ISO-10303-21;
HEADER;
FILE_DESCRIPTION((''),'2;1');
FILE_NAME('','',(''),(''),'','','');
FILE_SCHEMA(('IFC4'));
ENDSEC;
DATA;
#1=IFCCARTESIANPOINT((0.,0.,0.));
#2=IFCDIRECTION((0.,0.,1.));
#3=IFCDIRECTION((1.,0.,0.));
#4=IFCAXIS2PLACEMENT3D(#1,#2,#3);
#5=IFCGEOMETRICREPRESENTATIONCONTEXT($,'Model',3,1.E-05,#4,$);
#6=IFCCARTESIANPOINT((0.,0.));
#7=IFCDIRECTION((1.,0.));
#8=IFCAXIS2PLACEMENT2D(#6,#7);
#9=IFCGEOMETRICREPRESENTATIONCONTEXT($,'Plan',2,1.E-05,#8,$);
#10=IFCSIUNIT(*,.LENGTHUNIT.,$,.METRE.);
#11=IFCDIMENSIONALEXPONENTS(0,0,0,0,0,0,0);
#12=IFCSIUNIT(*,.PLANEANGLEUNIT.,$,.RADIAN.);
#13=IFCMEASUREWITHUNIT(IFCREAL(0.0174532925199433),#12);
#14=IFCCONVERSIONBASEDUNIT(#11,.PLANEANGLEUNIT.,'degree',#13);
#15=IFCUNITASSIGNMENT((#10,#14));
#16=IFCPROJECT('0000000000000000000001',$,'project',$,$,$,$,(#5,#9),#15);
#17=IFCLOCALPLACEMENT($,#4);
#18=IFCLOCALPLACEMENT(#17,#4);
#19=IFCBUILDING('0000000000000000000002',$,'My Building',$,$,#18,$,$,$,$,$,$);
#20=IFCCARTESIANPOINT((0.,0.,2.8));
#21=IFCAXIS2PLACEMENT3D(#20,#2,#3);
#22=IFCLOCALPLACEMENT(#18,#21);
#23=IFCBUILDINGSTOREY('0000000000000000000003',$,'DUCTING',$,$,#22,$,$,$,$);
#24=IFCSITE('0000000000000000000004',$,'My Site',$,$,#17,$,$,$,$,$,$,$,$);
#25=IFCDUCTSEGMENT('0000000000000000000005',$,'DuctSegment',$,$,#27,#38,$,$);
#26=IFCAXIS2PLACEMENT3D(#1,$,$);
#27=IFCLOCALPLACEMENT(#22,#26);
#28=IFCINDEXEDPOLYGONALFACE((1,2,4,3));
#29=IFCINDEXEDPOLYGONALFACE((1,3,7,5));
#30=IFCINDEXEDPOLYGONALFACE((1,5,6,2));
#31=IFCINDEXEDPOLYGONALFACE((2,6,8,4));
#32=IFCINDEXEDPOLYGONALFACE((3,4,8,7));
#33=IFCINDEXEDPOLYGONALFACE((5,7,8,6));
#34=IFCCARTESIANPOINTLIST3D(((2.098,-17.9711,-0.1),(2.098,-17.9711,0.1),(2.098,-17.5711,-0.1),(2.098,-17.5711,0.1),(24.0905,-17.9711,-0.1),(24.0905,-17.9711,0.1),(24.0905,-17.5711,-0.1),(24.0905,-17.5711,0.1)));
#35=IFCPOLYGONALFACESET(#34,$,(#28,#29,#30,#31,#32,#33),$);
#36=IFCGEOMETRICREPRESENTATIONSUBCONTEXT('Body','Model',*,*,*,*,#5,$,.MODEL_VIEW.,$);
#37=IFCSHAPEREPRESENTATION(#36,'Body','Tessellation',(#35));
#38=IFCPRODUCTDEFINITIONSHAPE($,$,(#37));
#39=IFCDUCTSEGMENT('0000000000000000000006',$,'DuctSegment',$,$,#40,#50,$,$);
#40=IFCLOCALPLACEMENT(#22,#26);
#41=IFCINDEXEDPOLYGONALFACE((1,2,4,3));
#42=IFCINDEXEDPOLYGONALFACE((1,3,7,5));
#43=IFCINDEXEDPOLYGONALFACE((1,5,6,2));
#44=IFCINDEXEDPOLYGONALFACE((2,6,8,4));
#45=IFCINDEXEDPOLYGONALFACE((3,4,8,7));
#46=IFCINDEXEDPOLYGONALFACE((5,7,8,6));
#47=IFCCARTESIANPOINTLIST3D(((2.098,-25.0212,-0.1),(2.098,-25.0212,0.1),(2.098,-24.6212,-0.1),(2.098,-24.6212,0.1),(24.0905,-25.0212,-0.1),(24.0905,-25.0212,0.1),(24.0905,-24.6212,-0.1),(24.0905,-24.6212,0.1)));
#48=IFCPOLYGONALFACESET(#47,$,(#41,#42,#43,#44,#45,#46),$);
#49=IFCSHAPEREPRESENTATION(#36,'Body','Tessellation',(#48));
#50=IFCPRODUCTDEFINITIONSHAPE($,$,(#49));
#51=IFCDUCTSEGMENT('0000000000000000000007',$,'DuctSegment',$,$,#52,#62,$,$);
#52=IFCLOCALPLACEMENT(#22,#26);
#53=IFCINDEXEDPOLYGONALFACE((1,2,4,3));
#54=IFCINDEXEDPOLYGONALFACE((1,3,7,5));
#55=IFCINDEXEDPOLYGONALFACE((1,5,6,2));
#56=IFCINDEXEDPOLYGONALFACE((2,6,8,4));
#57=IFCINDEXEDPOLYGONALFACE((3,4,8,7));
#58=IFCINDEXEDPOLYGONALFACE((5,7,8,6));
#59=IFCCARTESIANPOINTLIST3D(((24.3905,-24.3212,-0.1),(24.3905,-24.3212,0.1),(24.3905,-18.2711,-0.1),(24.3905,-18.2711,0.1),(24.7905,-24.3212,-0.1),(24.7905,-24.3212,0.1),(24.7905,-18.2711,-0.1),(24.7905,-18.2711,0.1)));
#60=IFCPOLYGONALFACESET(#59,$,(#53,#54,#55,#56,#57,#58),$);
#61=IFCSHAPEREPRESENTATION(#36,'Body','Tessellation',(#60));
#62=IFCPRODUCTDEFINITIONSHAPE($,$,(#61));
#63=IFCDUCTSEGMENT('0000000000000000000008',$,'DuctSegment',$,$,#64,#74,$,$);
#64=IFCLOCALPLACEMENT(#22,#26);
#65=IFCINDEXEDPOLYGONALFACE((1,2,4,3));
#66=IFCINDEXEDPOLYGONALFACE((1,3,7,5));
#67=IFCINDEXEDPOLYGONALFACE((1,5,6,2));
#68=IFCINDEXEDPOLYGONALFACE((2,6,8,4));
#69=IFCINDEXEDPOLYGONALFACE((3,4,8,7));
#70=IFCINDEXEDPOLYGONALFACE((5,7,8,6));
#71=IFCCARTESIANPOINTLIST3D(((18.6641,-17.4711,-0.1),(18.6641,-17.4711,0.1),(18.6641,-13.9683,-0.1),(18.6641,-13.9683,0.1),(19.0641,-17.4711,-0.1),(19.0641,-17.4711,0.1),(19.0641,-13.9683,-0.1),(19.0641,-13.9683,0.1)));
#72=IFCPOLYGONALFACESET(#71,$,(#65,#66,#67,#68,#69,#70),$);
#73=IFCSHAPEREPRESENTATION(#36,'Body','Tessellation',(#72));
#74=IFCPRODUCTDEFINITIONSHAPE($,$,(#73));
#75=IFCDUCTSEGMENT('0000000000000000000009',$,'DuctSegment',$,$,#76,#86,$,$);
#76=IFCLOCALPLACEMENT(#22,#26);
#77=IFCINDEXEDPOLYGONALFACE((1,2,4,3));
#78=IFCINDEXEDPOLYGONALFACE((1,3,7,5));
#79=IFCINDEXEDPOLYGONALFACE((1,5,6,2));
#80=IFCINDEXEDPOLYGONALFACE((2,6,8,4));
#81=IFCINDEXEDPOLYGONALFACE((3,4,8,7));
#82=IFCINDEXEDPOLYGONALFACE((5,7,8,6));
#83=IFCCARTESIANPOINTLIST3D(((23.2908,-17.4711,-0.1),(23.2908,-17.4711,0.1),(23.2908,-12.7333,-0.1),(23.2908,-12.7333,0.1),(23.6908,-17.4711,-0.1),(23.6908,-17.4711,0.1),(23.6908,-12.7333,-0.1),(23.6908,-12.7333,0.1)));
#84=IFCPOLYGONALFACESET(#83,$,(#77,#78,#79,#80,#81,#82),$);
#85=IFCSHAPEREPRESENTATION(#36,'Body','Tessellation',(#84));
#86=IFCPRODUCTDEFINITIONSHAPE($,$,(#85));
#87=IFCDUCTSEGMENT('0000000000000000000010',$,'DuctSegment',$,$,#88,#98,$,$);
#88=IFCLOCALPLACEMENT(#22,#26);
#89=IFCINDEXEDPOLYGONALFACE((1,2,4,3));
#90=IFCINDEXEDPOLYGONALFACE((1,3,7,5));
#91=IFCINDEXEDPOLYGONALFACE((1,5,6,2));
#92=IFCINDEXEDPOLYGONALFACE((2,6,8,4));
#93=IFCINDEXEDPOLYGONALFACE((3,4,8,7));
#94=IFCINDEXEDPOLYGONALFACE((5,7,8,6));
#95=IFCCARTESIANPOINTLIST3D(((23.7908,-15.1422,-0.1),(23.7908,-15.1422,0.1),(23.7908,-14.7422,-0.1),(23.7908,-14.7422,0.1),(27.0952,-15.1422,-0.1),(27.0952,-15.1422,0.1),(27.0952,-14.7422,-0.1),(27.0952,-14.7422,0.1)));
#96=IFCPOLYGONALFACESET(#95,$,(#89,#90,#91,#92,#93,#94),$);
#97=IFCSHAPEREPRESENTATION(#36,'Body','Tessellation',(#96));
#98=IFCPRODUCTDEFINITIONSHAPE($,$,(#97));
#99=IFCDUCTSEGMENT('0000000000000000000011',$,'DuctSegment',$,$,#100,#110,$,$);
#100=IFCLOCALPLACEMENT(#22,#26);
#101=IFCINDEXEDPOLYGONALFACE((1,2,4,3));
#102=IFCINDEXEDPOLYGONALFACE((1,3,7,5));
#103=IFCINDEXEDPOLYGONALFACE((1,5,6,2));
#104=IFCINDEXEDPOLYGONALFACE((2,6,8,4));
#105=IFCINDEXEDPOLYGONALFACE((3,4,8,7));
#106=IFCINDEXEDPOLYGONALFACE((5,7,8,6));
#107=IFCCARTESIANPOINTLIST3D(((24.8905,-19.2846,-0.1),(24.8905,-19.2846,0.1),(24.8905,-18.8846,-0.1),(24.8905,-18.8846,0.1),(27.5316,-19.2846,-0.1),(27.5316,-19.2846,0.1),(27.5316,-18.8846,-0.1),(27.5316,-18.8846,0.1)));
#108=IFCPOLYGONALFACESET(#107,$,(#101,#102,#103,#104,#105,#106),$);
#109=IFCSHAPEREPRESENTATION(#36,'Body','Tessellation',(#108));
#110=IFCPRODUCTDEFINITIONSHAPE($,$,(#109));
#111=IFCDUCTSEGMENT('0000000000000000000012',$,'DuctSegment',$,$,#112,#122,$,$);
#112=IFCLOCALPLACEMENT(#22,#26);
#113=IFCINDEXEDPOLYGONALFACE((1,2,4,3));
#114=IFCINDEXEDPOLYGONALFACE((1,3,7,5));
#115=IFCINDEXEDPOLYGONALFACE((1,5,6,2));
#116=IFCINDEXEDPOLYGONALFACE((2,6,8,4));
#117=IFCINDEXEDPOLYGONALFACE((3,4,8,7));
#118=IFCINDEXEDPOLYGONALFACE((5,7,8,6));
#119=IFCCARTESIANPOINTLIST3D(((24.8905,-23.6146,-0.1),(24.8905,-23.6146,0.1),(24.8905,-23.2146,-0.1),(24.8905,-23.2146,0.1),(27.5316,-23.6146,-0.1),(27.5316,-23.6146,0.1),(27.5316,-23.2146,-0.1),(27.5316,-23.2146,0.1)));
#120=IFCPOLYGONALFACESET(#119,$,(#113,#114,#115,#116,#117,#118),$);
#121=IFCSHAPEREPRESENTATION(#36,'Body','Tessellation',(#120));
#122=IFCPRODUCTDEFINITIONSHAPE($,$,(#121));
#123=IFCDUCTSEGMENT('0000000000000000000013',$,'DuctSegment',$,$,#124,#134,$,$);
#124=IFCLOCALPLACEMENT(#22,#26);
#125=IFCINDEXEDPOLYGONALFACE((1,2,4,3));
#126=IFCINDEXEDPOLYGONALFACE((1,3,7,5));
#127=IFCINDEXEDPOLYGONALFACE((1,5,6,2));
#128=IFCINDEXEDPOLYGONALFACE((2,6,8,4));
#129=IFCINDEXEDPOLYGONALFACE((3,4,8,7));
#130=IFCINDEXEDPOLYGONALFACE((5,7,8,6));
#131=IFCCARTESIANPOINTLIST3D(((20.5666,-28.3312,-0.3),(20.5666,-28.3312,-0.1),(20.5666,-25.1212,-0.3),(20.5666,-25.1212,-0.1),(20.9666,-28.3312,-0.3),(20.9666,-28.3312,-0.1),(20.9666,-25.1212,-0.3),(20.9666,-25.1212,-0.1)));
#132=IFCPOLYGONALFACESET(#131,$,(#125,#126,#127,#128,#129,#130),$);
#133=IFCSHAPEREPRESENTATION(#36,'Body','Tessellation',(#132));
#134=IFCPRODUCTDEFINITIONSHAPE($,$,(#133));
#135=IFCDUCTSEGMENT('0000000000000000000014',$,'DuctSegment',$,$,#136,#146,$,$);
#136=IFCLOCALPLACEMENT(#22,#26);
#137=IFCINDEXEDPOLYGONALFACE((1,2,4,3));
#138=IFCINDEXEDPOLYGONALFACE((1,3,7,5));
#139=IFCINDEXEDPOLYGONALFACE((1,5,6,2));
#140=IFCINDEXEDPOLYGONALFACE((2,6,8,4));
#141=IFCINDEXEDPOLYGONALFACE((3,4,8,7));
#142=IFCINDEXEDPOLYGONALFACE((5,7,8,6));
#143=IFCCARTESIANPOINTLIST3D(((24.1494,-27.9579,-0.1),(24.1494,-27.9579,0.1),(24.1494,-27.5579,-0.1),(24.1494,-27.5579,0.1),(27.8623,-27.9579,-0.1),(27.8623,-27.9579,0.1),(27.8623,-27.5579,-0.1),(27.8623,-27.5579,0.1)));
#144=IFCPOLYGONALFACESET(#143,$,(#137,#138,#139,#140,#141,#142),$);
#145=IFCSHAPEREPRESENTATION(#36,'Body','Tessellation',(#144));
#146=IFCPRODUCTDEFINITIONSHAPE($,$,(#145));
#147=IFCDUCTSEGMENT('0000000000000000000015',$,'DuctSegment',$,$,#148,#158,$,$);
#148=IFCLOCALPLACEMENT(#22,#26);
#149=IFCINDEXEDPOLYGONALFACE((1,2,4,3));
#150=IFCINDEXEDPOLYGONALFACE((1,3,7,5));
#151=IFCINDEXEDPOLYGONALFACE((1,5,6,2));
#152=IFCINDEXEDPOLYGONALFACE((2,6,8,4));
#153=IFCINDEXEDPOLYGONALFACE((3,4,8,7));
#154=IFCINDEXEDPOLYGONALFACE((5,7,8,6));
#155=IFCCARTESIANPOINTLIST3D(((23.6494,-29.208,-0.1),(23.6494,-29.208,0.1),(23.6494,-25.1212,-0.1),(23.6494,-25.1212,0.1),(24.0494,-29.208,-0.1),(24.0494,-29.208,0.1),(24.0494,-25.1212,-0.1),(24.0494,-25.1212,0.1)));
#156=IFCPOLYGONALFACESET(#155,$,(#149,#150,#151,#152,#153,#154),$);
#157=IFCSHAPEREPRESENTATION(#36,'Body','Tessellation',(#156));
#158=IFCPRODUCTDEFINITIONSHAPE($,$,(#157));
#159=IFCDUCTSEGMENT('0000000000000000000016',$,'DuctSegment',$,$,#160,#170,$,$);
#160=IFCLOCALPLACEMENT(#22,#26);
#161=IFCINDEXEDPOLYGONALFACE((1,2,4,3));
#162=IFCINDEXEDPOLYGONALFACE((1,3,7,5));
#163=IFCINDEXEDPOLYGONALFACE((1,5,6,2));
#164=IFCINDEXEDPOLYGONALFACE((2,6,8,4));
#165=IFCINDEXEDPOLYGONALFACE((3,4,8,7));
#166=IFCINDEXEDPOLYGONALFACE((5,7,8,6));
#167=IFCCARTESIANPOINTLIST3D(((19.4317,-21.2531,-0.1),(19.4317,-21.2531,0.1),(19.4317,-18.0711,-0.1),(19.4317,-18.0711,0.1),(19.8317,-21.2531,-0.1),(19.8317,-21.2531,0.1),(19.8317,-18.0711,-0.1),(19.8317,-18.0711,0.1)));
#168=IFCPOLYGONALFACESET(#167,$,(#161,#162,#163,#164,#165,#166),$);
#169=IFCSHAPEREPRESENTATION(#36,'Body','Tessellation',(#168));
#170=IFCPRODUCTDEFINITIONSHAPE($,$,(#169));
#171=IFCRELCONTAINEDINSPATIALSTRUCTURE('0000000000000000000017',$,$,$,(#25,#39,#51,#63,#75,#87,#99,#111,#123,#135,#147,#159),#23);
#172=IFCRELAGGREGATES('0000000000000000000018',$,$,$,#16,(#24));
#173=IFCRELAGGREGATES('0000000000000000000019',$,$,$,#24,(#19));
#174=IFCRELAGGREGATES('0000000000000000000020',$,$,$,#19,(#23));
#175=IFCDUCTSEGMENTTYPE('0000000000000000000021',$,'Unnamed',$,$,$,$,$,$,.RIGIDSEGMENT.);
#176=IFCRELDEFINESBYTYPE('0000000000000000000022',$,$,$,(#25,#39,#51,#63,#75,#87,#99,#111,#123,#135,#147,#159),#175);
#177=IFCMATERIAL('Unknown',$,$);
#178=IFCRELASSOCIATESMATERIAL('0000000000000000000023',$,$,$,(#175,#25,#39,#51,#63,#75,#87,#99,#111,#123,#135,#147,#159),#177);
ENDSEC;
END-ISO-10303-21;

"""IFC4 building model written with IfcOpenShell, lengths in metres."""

from ifc_helpers import new_model, entity, si_unit, converted_unit, frame, origin_with_axes, origin_2d_with_axis, place, context, subcontext, project, spatial, rectangle, extrude, material, material_profile, profile_set, profile_usage, type_object, element, save


model = new_model("IFC4")

# Units and contexts
model_context = context("Model", 3, precision=1e-05, world=origin_with_axes())
plan_context = context("Plan", 2, precision=1e-05, world=origin_2d_with_axis())
body_context = subcontext(model_context, "Body", "Model", "MODEL_VIEW")
ifc_project = project(units=[si_unit("LENGTHUNIT", "METRE"), converted_unit("PLANEANGLEUNIT", "degree", entity("IfcReal", 0.0174532925199433), si_unit("PLANEANGLEUNIT", "RADIAN"), dimensions=[0, 0, 0, 0, 0, 0, 0])], contexts=[model_context, plan_context])

# Site, building, storey
site_placement = place(None, origin_with_axes())
site = spatial("IfcSite", under=ifc_project, at=site_placement, Name="My Site")
building_placement = place(site_placement, origin_with_axes())
building = spatial("IfcBuilding", under=site, at=building_placement, Name="My Building")
storey_placement = place(building_placement, frame((0.0, 0.0, 2.8), z_axis=(0.0, 0.0, 1.0), x_axis=(1.0, 0.0, 0.0)))
storey = spatial("IfcBuildingStorey", under=building, at=storey_placement, Name="DUCTING")

# Duct segments
ifc_material = material(Name="Unknown")
ifc_material_profile_1 = material_profile(ifc_material, rectangle(XDim=0.4, YDim=0.2))
ifc_profile_set_1 = profile_set([ifc_material_profile_1])
ifc_profile_usage_1 = profile_usage(ifc_profile_set_1, cardinal=5)
duct_segment_type = type_object("IfcDuctSegmentType", Name="Unnamed", PredefinedType="RIGIDSEGMENT", material=ifc_profile_set_1)
duct_segment_1_placement = place(storey_placement, frame((24.0905, -17.7711, 0.0), z_axis=(-1.0, 0.0, 0.0), x_axis=(0.0, -1.0, 0.0)))
element("IfcDuctSegment", 1, at=duct_segment_1_placement, inside=storey, type_object=duct_segment_type, material=ifc_profile_usage_1, Name="DuctSegment", context=body_context, shape_type="SweptSolid", body=[
    extrude(rectangle(XDim=0.4, YDim=0.2), origin_with_axes(), (0.0, 0.0, 1.0), 21.9925),
])
ifc_profile_usage_2 = profile_usage(ifc_profile_set_1, cardinal=5)
duct_segment_2_placement = place(storey_placement, frame((24.0905, -24.8212, 0.0), z_axis=(-1.0, 0.0, 0.0), x_axis=(0.0, -1.0, 0.0)))
element("IfcDuctSegment", 2, at=duct_segment_2_placement, inside=storey, type_object=duct_segment_type, material=ifc_profile_usage_2, Name="DuctSegment", context=body_context, shape_type="SweptSolid", body=[
    extrude(rectangle(XDim=0.4, YDim=0.2), origin_with_axes(), (0.0, 0.0, 1.0), 21.9925),
])
ifc_profile_usage_3 = profile_usage(ifc_profile_set_1, cardinal=5)
duct_segment_3_placement = place(storey_placement, frame((24.5905, -18.2711, 0.0), z_axis=(0.0, -1.0, 0.0), x_axis=(-1.0, 0.0, 0.0)))
element("IfcDuctSegment", 3, at=duct_segment_3_placement, inside=storey, type_object=duct_segment_type, material=ifc_profile_usage_3, Name="DuctSegment", context=body_context, shape_type="SweptSolid", body=[
    extrude(rectangle(XDim=0.4, YDim=0.2), origin_with_axes(), (0.0, 0.0, 1.0), 6.0502),
])
ifc_profile_usage_4 = profile_usage(ifc_profile_set_1, cardinal=5)
duct_segment_4_placement = place(storey_placement, frame((18.8641, -13.9683, 0.0), z_axis=(0.0, -1.0, 0.0), x_axis=(1.0, 0.0, 0.0)))
element("IfcDuctSegment", 4, at=duct_segment_4_placement, inside=storey, type_object=duct_segment_type, material=ifc_profile_usage_4, Name="DuctSegment", context=body_context, shape_type="SweptSolid", body=[
    extrude(rectangle(XDim=0.4, YDim=0.2), origin_with_axes(), (0.0, 0.0, 1.0), 3.5028),
])
ifc_profile_usage_5 = profile_usage(ifc_profile_set_1, cardinal=5)
duct_segment_5_placement = place(storey_placement, frame((23.4908, -12.7333, 0.0), z_axis=(0.0, -1.0, 0.0), x_axis=(1.0, 0.0, 0.0)))
element("IfcDuctSegment", 5, at=duct_segment_5_placement, inside=storey, type_object=duct_segment_type, material=ifc_profile_usage_5, Name="DuctSegment", context=body_context, shape_type="SweptSolid", body=[
    extrude(rectangle(XDim=0.4, YDim=0.2), origin_with_axes(), (0.0, 0.0, 1.0), 4.7378),
])
ifc_profile_usage_6 = profile_usage(ifc_profile_set_1, cardinal=5)
duct_segment_6_placement = place(storey_placement, frame((27.0952, -14.9422, 0.0), z_axis=(-1.0, 0.0, 0.0), x_axis=(0.0, -1.0, 0.0)))
element("IfcDuctSegment", 6, at=duct_segment_6_placement, inside=storey, type_object=duct_segment_type, material=ifc_profile_usage_6, Name="DuctSegment", context=body_context, shape_type="SweptSolid", body=[
    extrude(rectangle(XDim=0.4, YDim=0.2), origin_with_axes(), (0.0, 0.0, 1.0), 3.3044),
])
ifc_profile_usage_7 = profile_usage(ifc_profile_set_1, cardinal=5)
duct_segment_7_placement = place(storey_placement, frame((27.5316, -19.0846, 0.0), z_axis=(-1.0, 0.0, 0.0), x_axis=(0.0, -1.0, 0.0)))
element("IfcDuctSegment", 7, at=duct_segment_7_placement, inside=storey, type_object=duct_segment_type, material=ifc_profile_usage_7, Name="DuctSegment", context=body_context, shape_type="SweptSolid", body=[
    extrude(rectangle(XDim=0.4, YDim=0.2), origin_with_axes(), (0.0, 0.0, 1.0), 2.6412),
])
ifc_profile_usage_8 = profile_usage(ifc_profile_set_1, cardinal=5)
duct_segment_8_placement = place(storey_placement, frame((27.5316, -23.4146, 0.0), z_axis=(-1.0, 0.0, 0.0), x_axis=(0.0, -1.0, 0.0)))
element("IfcDuctSegment", 8, at=duct_segment_8_placement, inside=storey, type_object=duct_segment_type, material=ifc_profile_usage_8, Name="DuctSegment", context=body_context, shape_type="SweptSolid", body=[
    extrude(rectangle(XDim=0.4, YDim=0.2), origin_with_axes(), (0.0, 0.0, 1.0), 2.6412),
])
ifc_profile_usage_9 = profile_usage(ifc_profile_set_1, cardinal=5)
duct_segment_9_placement = place(storey_placement, frame((20.7666, -28.3312, -0.2), z_axis=(0.0, 1.0, 0.0), x_axis=(-1.0, 0.0, 0.0)))
element("IfcDuctSegment", 9, at=duct_segment_9_placement, inside=storey, type_object=duct_segment_type, material=ifc_profile_usage_9, Name="DuctSegment", context=body_context, shape_type="SweptSolid", body=[
    extrude(rectangle(XDim=0.4, YDim=0.2), origin_with_axes(), (0.0, 0.0, 1.0), 3.2099),
])
ifc_profile_usage_10 = profile_usage(ifc_profile_set_1, cardinal=5)
duct_segment_10_placement = place(storey_placement, frame((27.8623, -27.7579, 0.0), z_axis=(-1.0, 0.0, 0.0), x_axis=(0.0, -1.0, 0.0)))
element("IfcDuctSegment", 10, at=duct_segment_10_placement, inside=storey, type_object=duct_segment_type, material=ifc_profile_usage_10, Name="DuctSegment", context=body_context, shape_type="SweptSolid", body=[
    extrude(rectangle(XDim=0.4, YDim=0.2), origin_with_axes(), (0.0, 0.0, 1.0), 3.7129),
])
ifc_profile_usage_11 = profile_usage(ifc_profile_set_1, cardinal=5)
duct_segment_11_placement = place(storey_placement, frame((23.8494, -29.208, 0.0), z_axis=(0.0, 1.0, 0.0), x_axis=(-1.0, 0.0, 0.0)))
element("IfcDuctSegment", 11, at=duct_segment_11_placement, inside=storey, type_object=duct_segment_type, material=ifc_profile_usage_11, Name="DuctSegment", context=body_context, shape_type="SweptSolid", body=[
    extrude(rectangle(XDim=0.4, YDim=0.2), origin_with_axes(), (0.0, 0.0, 1.0), 4.0867),
])
ifc_profile_usage_12 = profile_usage(ifc_profile_set_1, cardinal=5)
duct_segment_12_placement = place(storey_placement, frame((19.6317, -21.2531, 0.0), z_axis=(0.0, 1.0, 0.0), x_axis=(-1.0, 0.0, 0.0)))
element("IfcDuctSegment", 12, at=duct_segment_12_placement, inside=storey, type_object=duct_segment_type, material=ifc_profile_usage_12, Name="DuctSegment", context=body_context, shape_type="SweptSolid", body=[
    extrude(rectangle(XDim=0.4, YDim=0.2), origin_with_axes(), (0.0, 0.0, 1.0), 3.1821),
])

save(model, "model.ifc")
